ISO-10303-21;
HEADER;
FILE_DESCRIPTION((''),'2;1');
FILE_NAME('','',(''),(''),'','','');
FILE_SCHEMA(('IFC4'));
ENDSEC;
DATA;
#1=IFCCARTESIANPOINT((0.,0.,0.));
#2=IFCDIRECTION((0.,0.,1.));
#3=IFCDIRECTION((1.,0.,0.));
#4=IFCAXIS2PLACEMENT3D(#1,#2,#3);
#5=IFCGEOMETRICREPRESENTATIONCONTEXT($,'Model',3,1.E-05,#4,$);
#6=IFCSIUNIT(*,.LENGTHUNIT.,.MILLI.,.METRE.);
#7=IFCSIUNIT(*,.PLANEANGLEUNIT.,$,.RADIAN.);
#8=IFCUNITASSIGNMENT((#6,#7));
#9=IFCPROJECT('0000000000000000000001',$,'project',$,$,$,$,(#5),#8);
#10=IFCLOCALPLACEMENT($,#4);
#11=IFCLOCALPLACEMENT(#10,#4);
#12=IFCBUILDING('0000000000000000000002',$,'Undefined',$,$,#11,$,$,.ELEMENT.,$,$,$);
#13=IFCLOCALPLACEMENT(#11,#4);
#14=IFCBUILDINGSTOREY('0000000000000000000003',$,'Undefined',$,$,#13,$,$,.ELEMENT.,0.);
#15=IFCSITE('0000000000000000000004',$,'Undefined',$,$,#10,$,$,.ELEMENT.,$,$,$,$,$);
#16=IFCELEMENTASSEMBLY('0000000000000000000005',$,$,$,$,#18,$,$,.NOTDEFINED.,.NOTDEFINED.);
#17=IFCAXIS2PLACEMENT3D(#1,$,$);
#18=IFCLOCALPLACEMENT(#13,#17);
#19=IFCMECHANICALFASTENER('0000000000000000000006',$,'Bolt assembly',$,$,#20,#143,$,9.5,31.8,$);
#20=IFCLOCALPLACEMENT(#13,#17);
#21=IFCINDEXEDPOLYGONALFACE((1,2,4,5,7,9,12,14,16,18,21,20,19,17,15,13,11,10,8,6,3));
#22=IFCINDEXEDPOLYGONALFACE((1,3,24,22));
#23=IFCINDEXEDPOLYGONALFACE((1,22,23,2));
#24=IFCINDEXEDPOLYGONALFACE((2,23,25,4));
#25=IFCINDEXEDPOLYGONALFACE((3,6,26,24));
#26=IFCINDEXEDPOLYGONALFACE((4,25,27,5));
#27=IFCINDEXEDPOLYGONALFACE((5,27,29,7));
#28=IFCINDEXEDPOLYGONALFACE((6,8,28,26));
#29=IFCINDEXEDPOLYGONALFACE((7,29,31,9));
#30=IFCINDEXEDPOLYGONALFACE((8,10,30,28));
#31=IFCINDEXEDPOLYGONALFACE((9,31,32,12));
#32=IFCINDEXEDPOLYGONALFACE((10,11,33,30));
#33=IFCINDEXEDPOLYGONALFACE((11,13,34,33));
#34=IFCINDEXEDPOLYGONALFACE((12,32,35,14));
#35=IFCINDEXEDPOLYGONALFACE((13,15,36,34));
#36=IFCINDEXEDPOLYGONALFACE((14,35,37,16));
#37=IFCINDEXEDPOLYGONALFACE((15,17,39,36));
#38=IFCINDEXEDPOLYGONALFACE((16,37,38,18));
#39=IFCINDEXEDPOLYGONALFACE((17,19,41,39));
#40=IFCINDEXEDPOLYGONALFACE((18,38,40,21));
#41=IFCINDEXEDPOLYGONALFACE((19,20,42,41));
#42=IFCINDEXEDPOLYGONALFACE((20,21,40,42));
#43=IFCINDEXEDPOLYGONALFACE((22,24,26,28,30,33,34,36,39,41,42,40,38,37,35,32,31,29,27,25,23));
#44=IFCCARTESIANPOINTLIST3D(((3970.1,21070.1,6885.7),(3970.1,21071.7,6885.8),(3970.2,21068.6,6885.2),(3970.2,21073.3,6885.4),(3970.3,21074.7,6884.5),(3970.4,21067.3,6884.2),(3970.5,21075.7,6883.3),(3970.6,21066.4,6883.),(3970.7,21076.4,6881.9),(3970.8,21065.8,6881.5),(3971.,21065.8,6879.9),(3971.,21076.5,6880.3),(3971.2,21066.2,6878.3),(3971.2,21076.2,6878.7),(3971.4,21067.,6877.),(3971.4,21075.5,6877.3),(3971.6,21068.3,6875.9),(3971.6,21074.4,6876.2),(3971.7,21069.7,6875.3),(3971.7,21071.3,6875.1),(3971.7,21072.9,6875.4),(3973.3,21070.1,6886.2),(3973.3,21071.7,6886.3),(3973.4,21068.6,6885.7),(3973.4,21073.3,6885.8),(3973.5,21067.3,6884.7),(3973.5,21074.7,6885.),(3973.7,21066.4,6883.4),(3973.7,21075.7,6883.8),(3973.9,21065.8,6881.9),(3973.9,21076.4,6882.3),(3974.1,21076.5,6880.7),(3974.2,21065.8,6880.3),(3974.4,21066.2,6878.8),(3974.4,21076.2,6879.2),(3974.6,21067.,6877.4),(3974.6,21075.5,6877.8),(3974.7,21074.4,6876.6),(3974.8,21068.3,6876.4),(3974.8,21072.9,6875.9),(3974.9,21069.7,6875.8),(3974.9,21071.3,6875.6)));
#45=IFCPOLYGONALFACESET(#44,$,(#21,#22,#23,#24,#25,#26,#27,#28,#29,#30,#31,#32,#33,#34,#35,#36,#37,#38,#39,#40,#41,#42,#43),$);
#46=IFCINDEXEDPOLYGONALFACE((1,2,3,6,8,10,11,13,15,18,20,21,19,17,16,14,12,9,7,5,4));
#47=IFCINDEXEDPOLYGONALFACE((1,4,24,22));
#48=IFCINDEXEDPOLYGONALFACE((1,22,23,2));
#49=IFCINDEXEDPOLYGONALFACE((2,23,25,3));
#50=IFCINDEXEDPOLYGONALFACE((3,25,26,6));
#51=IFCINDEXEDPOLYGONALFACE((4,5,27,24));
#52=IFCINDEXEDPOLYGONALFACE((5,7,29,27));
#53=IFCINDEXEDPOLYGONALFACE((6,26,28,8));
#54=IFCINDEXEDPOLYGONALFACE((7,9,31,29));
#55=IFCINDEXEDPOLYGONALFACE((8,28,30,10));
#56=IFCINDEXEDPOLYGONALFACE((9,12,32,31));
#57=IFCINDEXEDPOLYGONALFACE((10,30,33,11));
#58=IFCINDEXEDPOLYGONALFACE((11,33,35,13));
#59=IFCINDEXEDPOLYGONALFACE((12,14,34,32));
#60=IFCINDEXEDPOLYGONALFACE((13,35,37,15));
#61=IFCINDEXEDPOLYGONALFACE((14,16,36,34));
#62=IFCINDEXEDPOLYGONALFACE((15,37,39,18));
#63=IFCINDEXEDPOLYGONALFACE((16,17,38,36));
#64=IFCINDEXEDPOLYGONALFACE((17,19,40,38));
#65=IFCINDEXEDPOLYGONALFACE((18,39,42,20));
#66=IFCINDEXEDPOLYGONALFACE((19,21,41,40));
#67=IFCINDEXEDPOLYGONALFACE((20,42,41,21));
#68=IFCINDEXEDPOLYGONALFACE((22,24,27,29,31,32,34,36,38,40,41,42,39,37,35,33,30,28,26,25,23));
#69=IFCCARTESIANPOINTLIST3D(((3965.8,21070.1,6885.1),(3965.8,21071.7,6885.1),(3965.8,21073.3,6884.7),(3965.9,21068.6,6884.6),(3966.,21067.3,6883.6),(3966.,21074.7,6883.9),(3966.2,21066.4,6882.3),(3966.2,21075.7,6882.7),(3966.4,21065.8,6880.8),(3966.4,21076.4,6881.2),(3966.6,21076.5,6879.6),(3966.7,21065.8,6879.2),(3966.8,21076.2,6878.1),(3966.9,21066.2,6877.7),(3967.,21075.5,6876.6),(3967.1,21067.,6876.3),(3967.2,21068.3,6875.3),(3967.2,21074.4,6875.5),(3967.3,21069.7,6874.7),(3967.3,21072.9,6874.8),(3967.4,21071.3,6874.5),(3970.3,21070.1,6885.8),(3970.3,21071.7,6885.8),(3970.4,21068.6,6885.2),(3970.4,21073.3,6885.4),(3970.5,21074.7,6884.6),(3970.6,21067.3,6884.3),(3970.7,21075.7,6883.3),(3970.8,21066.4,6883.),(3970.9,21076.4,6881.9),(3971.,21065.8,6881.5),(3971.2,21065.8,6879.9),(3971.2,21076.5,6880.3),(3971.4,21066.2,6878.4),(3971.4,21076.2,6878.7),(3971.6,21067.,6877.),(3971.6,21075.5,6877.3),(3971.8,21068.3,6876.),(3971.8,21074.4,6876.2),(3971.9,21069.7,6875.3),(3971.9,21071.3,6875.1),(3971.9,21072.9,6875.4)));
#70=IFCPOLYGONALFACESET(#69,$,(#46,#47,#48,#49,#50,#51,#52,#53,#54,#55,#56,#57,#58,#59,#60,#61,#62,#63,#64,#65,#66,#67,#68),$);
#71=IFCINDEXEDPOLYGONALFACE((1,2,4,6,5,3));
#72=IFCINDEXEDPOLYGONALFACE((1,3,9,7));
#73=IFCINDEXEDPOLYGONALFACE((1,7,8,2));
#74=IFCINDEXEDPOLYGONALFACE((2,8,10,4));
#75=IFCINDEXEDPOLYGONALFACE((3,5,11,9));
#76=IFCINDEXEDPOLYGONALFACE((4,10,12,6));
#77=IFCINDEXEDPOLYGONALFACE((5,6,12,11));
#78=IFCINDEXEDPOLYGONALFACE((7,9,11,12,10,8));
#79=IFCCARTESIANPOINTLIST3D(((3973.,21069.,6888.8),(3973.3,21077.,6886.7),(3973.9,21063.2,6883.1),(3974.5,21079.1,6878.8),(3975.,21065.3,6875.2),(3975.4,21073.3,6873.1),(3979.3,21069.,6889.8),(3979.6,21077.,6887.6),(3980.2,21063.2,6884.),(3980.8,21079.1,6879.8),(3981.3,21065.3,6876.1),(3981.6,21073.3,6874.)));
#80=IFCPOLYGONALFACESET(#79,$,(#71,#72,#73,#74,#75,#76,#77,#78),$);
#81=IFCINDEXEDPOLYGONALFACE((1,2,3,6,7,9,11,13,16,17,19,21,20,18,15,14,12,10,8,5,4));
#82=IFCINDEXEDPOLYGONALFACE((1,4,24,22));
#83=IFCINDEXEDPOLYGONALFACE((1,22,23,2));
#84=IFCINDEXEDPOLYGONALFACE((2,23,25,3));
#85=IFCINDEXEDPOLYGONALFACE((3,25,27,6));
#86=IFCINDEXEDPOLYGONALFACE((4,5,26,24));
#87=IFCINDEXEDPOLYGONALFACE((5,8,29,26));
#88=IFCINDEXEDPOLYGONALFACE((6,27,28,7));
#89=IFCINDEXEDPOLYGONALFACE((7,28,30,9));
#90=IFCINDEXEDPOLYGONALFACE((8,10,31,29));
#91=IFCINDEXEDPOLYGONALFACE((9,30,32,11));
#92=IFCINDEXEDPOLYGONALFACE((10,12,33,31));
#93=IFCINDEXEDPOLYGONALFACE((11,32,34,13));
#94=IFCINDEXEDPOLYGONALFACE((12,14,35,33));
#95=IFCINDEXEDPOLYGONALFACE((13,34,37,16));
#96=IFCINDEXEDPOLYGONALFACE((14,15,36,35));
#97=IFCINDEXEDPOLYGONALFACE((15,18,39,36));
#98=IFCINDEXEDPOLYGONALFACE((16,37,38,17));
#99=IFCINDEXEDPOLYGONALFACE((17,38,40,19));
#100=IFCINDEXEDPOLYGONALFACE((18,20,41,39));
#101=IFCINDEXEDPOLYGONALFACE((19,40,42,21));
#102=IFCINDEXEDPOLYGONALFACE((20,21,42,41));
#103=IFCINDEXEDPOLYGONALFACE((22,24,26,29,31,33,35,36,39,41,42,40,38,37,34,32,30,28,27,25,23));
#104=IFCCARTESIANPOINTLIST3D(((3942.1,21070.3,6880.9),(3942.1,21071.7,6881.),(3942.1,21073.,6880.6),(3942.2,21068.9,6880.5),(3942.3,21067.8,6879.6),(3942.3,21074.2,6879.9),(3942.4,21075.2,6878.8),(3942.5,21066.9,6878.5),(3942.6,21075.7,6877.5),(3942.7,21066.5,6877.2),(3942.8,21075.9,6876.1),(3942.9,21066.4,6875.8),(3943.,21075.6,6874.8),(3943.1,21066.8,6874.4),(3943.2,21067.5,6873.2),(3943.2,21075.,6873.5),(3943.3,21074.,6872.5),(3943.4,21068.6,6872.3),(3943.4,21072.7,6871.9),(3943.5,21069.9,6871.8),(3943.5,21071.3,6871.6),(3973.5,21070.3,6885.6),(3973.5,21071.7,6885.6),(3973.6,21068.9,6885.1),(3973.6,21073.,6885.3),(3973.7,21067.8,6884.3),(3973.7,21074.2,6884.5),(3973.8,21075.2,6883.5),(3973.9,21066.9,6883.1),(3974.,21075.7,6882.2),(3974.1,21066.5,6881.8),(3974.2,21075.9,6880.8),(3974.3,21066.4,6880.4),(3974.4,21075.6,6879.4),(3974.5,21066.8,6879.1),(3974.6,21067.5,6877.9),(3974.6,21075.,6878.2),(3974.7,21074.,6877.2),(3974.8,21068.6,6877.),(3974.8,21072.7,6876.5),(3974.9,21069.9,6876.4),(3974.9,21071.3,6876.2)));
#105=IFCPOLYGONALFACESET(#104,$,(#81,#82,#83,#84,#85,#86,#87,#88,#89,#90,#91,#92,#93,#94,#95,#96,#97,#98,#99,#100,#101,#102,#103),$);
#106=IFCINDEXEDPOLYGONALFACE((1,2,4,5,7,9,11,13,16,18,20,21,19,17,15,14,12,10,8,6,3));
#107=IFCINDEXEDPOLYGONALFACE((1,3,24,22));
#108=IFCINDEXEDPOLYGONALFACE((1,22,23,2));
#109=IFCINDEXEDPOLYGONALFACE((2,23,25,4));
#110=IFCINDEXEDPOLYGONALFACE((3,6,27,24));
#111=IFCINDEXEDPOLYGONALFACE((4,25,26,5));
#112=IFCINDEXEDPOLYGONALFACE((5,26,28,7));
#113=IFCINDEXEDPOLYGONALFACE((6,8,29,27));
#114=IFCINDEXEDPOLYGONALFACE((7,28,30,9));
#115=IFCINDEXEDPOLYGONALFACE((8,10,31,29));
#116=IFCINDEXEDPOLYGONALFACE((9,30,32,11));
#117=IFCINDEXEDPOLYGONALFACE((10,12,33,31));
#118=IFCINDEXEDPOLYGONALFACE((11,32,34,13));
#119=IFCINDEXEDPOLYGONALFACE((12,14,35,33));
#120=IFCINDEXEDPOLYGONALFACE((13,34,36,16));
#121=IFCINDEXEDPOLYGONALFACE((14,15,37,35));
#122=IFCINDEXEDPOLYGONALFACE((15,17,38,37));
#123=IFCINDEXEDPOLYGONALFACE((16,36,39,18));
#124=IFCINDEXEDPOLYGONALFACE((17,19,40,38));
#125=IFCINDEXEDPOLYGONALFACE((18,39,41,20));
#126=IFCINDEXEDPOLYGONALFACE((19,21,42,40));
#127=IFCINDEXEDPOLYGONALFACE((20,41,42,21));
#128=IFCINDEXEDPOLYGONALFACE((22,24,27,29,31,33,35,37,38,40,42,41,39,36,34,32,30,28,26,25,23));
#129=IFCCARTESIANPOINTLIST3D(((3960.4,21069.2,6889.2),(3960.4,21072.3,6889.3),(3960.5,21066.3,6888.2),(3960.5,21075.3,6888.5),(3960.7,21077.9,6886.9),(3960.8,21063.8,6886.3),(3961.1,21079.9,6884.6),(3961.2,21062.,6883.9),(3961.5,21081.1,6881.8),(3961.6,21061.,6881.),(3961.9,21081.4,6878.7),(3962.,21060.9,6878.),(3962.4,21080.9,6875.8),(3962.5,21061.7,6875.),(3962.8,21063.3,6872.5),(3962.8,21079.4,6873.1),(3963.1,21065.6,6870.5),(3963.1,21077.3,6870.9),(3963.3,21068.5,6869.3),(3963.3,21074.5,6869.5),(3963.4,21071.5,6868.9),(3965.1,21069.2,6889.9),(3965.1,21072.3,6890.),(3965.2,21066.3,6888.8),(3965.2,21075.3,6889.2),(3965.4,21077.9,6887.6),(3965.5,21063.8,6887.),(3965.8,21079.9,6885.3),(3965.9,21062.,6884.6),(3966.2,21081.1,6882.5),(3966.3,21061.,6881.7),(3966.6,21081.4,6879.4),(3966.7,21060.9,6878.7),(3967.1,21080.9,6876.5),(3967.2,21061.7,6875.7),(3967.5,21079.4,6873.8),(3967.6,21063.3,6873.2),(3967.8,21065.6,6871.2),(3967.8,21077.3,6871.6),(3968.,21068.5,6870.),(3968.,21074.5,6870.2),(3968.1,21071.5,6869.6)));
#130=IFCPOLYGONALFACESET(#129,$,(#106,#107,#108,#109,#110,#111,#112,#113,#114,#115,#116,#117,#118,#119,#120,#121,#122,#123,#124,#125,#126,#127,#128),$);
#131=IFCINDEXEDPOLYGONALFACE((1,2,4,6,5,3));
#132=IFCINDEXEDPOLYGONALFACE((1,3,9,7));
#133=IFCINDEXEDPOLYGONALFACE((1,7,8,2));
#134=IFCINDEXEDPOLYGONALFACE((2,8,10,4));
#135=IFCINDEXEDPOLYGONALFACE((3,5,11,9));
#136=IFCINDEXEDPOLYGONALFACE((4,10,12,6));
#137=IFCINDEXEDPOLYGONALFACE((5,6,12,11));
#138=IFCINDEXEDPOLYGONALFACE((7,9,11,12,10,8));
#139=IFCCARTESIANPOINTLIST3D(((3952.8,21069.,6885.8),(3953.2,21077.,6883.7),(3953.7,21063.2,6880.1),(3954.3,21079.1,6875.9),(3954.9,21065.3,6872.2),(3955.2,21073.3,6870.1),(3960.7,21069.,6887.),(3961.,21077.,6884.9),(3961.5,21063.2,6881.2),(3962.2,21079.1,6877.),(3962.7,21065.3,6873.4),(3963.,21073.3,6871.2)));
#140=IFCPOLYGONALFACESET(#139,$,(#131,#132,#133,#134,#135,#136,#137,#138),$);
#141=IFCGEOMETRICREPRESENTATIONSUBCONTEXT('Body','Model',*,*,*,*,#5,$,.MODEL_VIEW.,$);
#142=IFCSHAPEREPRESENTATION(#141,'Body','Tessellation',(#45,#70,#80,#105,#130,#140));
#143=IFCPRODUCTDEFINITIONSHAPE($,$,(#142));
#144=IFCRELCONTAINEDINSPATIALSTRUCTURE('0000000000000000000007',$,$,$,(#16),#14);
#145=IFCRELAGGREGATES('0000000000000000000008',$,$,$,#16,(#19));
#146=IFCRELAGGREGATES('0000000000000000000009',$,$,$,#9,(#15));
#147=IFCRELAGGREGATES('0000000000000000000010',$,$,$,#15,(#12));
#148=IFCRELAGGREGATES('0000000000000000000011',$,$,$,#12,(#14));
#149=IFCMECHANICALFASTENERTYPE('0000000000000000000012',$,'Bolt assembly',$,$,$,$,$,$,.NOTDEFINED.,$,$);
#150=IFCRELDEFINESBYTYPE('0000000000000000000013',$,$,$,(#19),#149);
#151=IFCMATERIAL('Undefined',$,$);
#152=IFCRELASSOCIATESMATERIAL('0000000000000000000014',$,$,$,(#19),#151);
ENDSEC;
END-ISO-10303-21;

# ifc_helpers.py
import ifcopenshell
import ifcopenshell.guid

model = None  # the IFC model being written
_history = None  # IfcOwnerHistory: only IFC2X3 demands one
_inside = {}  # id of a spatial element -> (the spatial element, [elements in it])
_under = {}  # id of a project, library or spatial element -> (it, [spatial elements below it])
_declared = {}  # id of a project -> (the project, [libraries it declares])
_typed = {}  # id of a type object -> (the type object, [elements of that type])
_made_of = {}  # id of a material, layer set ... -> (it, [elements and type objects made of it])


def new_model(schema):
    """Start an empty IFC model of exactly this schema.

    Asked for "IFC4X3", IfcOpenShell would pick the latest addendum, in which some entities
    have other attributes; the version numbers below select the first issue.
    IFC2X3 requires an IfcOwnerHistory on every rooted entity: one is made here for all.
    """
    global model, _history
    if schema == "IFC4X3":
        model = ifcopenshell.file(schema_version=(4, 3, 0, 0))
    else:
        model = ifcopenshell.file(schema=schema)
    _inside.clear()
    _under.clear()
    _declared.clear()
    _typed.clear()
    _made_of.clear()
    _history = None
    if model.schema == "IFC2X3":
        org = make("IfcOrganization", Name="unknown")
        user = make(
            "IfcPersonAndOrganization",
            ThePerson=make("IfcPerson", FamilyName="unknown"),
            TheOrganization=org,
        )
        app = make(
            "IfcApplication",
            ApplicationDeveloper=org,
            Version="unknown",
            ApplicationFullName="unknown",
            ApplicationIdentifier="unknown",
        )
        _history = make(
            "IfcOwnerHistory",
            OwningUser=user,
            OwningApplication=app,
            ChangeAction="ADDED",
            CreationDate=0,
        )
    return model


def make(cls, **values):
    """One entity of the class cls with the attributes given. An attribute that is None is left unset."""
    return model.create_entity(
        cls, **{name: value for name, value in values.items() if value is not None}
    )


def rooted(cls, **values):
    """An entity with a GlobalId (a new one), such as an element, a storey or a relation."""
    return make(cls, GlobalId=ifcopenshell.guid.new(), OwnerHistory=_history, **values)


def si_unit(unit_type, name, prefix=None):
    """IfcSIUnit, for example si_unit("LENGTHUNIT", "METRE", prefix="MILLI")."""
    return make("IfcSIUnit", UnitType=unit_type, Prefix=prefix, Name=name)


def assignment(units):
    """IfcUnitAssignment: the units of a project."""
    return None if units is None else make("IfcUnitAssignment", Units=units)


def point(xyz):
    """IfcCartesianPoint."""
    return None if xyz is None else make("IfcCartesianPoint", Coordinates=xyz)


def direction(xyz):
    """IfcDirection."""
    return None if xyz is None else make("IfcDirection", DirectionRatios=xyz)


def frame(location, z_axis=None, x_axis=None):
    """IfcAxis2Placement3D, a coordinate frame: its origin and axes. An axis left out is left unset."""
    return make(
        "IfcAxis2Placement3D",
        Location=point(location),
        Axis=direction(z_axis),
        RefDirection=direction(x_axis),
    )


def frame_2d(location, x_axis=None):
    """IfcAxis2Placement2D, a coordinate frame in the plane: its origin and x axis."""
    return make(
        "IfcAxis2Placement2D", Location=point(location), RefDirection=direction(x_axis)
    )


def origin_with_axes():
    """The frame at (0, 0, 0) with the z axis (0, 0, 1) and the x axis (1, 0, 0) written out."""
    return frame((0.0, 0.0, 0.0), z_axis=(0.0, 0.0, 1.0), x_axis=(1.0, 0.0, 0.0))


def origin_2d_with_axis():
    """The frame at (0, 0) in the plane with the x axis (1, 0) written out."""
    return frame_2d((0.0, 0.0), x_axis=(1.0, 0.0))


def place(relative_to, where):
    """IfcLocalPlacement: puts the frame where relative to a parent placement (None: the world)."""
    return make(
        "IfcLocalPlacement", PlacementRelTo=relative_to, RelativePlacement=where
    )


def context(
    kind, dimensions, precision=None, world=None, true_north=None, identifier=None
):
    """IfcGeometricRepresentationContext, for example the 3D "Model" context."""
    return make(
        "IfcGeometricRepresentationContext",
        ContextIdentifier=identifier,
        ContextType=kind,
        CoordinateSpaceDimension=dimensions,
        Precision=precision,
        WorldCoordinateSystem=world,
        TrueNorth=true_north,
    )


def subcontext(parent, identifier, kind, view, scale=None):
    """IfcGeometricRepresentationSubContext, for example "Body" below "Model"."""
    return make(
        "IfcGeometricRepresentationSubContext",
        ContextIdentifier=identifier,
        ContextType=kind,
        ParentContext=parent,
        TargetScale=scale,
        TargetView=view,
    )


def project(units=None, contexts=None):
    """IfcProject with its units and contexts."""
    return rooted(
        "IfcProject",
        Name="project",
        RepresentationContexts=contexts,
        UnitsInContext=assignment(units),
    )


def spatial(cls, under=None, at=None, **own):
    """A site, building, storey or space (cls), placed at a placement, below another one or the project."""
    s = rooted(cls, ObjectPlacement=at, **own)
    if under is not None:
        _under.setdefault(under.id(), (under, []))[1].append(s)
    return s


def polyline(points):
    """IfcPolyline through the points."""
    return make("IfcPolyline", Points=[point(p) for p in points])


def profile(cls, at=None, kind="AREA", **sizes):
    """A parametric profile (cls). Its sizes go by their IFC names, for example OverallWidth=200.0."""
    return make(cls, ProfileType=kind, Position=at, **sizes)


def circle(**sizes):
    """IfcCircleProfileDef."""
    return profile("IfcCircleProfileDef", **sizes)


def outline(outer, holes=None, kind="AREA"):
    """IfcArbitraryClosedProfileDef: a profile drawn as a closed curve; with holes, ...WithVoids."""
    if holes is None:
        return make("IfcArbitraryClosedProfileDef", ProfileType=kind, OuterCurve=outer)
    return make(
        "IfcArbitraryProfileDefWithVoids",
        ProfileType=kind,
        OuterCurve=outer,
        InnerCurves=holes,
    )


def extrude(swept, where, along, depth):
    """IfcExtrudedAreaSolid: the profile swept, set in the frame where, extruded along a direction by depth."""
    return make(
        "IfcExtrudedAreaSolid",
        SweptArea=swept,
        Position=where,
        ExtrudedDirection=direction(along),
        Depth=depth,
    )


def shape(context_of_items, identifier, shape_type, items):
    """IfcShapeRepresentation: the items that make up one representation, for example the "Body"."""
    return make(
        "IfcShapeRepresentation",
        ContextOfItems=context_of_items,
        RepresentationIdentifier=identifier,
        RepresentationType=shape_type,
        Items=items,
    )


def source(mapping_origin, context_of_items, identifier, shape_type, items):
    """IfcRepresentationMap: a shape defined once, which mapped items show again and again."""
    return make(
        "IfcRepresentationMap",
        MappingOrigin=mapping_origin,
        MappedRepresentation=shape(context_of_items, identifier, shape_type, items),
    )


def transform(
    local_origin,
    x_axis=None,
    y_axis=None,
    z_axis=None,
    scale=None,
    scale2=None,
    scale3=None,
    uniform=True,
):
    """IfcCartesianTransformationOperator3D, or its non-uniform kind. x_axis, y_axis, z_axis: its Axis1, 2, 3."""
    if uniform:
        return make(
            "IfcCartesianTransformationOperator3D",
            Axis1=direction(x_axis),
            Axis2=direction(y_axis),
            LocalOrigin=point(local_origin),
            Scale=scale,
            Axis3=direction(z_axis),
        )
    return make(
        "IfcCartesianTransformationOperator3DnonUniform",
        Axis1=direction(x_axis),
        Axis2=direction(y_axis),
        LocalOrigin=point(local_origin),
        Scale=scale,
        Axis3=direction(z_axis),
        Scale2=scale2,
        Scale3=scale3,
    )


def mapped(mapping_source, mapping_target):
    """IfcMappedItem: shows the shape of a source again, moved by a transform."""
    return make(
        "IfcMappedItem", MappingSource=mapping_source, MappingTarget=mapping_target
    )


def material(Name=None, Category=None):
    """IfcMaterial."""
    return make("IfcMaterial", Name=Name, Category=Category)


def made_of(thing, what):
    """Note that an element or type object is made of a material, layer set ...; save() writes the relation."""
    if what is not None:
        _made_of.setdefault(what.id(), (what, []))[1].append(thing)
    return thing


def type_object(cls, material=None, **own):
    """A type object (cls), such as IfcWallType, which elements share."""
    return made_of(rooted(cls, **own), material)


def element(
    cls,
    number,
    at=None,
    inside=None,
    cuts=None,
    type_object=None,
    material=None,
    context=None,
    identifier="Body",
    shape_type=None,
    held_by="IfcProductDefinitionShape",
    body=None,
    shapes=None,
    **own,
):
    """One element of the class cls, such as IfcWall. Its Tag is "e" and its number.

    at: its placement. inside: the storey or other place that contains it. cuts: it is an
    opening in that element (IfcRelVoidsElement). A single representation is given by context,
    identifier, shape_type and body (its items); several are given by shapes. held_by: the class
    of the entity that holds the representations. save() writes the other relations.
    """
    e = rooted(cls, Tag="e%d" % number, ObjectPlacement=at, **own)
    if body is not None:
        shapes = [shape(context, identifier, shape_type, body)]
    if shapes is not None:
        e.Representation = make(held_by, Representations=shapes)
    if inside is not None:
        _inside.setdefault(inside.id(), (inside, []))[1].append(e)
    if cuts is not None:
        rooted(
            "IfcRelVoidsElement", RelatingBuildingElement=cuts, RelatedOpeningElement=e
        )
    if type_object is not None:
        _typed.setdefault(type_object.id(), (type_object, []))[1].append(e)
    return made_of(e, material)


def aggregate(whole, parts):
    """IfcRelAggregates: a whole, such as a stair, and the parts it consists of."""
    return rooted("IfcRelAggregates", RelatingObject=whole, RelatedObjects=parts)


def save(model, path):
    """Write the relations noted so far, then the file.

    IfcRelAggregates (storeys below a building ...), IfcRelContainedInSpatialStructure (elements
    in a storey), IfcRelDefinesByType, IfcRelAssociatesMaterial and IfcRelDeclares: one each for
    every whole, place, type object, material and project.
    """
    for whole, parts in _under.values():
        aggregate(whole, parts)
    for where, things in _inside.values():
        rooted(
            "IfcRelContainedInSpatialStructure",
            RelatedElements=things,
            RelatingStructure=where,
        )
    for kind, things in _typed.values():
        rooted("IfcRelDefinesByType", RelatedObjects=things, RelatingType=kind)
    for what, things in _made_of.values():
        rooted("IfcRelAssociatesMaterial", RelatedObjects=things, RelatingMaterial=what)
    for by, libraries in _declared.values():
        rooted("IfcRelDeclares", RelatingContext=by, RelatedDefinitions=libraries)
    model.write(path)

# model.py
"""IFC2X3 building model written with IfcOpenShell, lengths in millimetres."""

from ifc_helpers import new_model, si_unit, frame, origin_with_axes, origin_2d_with_axis, place, context, subcontext, project, spatial, polyline, circle, outline, extrude, source, transform, mapped, material, type_object, element, aggregate, save


model = new_model("IFC2X3")

# Units and contexts
model_context = context("Model", 3, precision=1e-05, world=origin_with_axes())
body_context = subcontext(model_context, "Body", "Model", "MODEL_VIEW")
ifc_project = project(units=[si_unit("LENGTHUNIT", "METRE", prefix="MILLI"), si_unit("PLANEANGLEUNIT", "RADIAN")], contexts=[model_context])

# Site, building, storey
site_placement = place(None, origin_with_axes())
site = spatial("IfcSite", under=ifc_project, at=site_placement, Name="Undefined", CompositionType="ELEMENT")
building_placement = place(site_placement, origin_with_axes())
building = spatial("IfcBuilding", under=site, at=building_placement, Name="Undefined", CompositionType="ELEMENT")
storey_placement = place(building_placement, origin_with_axes())
storey = spatial("IfcBuildingStorey", under=building, at=storey_placement, Name="Undefined", CompositionType="ELEMENT", Elevation=0.0)

# Element assembly
assembly_1_placement = place(storey_placement, origin_with_axes())
assembly_1 = element("IfcElementAssembly", 1, at=assembly_1_placement, inside=storey, AssemblyPlace="NOTDEFINED", PredefinedType="NOTDEFINED")

# Shared definitions
ifc_material_1 = material(Name="Undefined")
mechanical_fastener_type = type_object("IfcMechanicalFastenerType", Name="Bolt assembly")

# Mechanical fastener
shared_shape_1 = source(origin_with_axes(), body_context, "Body", "SweptSolid", [
    extrude(circle(Radius=5.4, at=origin_2d_with_axis()), frame((0.0, -3.1, 0.0), z_axis=(0.0, 1.0, 0.0), x_axis=(1.0, 0.0, 0.0)), (0.0, 0.0, 1.0), 3.2),
    extrude(circle(Radius=5.4, at=origin_2d_with_axis()), frame((0.0, -0.1, 0.0), z_axis=(0.0, 1.0, 0.0), x_axis=(1.0, 0.0, 0.0)), (0.0, 0.0, 1.0), 4.6),
    extrude(outline(polyline([(7.1, -4.1), (7.1, 4.1), (0.0, 8.2), (-7.1, 4.1), (-7.1, -4.1), (0.0, -8.2), (7.1, -4.1)])), frame((0.0, -9.6, 0.0), z_axis=(0.0, 1.0, 0.0), x_axis=(1.0, 0.0, 0.0)), (0.0, 0.0, 1.0), 6.3),
    extrude(circle(Radius=4.8, at=origin_2d_with_axis()), frame((0.0, -3.2, 0.0), z_axis=(0.0, 1.0, 0.0), x_axis=(1.0, 0.0, 0.0)), (0.0, 0.0, 1.0), 31.8),
    extrude(circle(Radius=10.3, at=origin_2d_with_axis()), frame((0.0, 4.5, 0.0), z_axis=(0.0, 1.0, 0.0), x_axis=(1.0, 0.0, 0.0)), (0.0, 0.0, 1.0), 4.8),
    extrude(outline(polyline([(7.1, -4.1), (7.1, 4.1), (0.0, 8.2), (-7.1, 4.1), (-7.1, -4.1), (0.0, -8.2), (7.1, -4.1)])), frame((0.0, 9.3, 0.0), z_axis=(0.0, 1.0, 0.0), x_axis=(1.0, 0.0, 0.0)), (0.0, 0.0, 1.0), 7.9),
])
mechanical_fastener_1_placement = place(assembly_1_placement, frame((3971.0, 21071.1, 6880.5), z_axis=(0.103381, -0.707107, -0.699509), x_axis=(-0.103381, -0.707107, 0.699509)))
mechanical_fastener_1 = element("IfcMechanicalFastener", 2, at=mechanical_fastener_1_placement, type_object=mechanical_fastener_type, material=ifc_material_1, Name="Bolt assembly", NominalDiameter=9.5, NominalLength=31.8, context=body_context, shape_type="MappedRepresentation", body=[
    mapped(shared_shape_1, transform((0.0, 0.0, 0.0))),
])
aggregate(assembly_1, [mechanical_fastener_1])

save(model, "model.ifc")
